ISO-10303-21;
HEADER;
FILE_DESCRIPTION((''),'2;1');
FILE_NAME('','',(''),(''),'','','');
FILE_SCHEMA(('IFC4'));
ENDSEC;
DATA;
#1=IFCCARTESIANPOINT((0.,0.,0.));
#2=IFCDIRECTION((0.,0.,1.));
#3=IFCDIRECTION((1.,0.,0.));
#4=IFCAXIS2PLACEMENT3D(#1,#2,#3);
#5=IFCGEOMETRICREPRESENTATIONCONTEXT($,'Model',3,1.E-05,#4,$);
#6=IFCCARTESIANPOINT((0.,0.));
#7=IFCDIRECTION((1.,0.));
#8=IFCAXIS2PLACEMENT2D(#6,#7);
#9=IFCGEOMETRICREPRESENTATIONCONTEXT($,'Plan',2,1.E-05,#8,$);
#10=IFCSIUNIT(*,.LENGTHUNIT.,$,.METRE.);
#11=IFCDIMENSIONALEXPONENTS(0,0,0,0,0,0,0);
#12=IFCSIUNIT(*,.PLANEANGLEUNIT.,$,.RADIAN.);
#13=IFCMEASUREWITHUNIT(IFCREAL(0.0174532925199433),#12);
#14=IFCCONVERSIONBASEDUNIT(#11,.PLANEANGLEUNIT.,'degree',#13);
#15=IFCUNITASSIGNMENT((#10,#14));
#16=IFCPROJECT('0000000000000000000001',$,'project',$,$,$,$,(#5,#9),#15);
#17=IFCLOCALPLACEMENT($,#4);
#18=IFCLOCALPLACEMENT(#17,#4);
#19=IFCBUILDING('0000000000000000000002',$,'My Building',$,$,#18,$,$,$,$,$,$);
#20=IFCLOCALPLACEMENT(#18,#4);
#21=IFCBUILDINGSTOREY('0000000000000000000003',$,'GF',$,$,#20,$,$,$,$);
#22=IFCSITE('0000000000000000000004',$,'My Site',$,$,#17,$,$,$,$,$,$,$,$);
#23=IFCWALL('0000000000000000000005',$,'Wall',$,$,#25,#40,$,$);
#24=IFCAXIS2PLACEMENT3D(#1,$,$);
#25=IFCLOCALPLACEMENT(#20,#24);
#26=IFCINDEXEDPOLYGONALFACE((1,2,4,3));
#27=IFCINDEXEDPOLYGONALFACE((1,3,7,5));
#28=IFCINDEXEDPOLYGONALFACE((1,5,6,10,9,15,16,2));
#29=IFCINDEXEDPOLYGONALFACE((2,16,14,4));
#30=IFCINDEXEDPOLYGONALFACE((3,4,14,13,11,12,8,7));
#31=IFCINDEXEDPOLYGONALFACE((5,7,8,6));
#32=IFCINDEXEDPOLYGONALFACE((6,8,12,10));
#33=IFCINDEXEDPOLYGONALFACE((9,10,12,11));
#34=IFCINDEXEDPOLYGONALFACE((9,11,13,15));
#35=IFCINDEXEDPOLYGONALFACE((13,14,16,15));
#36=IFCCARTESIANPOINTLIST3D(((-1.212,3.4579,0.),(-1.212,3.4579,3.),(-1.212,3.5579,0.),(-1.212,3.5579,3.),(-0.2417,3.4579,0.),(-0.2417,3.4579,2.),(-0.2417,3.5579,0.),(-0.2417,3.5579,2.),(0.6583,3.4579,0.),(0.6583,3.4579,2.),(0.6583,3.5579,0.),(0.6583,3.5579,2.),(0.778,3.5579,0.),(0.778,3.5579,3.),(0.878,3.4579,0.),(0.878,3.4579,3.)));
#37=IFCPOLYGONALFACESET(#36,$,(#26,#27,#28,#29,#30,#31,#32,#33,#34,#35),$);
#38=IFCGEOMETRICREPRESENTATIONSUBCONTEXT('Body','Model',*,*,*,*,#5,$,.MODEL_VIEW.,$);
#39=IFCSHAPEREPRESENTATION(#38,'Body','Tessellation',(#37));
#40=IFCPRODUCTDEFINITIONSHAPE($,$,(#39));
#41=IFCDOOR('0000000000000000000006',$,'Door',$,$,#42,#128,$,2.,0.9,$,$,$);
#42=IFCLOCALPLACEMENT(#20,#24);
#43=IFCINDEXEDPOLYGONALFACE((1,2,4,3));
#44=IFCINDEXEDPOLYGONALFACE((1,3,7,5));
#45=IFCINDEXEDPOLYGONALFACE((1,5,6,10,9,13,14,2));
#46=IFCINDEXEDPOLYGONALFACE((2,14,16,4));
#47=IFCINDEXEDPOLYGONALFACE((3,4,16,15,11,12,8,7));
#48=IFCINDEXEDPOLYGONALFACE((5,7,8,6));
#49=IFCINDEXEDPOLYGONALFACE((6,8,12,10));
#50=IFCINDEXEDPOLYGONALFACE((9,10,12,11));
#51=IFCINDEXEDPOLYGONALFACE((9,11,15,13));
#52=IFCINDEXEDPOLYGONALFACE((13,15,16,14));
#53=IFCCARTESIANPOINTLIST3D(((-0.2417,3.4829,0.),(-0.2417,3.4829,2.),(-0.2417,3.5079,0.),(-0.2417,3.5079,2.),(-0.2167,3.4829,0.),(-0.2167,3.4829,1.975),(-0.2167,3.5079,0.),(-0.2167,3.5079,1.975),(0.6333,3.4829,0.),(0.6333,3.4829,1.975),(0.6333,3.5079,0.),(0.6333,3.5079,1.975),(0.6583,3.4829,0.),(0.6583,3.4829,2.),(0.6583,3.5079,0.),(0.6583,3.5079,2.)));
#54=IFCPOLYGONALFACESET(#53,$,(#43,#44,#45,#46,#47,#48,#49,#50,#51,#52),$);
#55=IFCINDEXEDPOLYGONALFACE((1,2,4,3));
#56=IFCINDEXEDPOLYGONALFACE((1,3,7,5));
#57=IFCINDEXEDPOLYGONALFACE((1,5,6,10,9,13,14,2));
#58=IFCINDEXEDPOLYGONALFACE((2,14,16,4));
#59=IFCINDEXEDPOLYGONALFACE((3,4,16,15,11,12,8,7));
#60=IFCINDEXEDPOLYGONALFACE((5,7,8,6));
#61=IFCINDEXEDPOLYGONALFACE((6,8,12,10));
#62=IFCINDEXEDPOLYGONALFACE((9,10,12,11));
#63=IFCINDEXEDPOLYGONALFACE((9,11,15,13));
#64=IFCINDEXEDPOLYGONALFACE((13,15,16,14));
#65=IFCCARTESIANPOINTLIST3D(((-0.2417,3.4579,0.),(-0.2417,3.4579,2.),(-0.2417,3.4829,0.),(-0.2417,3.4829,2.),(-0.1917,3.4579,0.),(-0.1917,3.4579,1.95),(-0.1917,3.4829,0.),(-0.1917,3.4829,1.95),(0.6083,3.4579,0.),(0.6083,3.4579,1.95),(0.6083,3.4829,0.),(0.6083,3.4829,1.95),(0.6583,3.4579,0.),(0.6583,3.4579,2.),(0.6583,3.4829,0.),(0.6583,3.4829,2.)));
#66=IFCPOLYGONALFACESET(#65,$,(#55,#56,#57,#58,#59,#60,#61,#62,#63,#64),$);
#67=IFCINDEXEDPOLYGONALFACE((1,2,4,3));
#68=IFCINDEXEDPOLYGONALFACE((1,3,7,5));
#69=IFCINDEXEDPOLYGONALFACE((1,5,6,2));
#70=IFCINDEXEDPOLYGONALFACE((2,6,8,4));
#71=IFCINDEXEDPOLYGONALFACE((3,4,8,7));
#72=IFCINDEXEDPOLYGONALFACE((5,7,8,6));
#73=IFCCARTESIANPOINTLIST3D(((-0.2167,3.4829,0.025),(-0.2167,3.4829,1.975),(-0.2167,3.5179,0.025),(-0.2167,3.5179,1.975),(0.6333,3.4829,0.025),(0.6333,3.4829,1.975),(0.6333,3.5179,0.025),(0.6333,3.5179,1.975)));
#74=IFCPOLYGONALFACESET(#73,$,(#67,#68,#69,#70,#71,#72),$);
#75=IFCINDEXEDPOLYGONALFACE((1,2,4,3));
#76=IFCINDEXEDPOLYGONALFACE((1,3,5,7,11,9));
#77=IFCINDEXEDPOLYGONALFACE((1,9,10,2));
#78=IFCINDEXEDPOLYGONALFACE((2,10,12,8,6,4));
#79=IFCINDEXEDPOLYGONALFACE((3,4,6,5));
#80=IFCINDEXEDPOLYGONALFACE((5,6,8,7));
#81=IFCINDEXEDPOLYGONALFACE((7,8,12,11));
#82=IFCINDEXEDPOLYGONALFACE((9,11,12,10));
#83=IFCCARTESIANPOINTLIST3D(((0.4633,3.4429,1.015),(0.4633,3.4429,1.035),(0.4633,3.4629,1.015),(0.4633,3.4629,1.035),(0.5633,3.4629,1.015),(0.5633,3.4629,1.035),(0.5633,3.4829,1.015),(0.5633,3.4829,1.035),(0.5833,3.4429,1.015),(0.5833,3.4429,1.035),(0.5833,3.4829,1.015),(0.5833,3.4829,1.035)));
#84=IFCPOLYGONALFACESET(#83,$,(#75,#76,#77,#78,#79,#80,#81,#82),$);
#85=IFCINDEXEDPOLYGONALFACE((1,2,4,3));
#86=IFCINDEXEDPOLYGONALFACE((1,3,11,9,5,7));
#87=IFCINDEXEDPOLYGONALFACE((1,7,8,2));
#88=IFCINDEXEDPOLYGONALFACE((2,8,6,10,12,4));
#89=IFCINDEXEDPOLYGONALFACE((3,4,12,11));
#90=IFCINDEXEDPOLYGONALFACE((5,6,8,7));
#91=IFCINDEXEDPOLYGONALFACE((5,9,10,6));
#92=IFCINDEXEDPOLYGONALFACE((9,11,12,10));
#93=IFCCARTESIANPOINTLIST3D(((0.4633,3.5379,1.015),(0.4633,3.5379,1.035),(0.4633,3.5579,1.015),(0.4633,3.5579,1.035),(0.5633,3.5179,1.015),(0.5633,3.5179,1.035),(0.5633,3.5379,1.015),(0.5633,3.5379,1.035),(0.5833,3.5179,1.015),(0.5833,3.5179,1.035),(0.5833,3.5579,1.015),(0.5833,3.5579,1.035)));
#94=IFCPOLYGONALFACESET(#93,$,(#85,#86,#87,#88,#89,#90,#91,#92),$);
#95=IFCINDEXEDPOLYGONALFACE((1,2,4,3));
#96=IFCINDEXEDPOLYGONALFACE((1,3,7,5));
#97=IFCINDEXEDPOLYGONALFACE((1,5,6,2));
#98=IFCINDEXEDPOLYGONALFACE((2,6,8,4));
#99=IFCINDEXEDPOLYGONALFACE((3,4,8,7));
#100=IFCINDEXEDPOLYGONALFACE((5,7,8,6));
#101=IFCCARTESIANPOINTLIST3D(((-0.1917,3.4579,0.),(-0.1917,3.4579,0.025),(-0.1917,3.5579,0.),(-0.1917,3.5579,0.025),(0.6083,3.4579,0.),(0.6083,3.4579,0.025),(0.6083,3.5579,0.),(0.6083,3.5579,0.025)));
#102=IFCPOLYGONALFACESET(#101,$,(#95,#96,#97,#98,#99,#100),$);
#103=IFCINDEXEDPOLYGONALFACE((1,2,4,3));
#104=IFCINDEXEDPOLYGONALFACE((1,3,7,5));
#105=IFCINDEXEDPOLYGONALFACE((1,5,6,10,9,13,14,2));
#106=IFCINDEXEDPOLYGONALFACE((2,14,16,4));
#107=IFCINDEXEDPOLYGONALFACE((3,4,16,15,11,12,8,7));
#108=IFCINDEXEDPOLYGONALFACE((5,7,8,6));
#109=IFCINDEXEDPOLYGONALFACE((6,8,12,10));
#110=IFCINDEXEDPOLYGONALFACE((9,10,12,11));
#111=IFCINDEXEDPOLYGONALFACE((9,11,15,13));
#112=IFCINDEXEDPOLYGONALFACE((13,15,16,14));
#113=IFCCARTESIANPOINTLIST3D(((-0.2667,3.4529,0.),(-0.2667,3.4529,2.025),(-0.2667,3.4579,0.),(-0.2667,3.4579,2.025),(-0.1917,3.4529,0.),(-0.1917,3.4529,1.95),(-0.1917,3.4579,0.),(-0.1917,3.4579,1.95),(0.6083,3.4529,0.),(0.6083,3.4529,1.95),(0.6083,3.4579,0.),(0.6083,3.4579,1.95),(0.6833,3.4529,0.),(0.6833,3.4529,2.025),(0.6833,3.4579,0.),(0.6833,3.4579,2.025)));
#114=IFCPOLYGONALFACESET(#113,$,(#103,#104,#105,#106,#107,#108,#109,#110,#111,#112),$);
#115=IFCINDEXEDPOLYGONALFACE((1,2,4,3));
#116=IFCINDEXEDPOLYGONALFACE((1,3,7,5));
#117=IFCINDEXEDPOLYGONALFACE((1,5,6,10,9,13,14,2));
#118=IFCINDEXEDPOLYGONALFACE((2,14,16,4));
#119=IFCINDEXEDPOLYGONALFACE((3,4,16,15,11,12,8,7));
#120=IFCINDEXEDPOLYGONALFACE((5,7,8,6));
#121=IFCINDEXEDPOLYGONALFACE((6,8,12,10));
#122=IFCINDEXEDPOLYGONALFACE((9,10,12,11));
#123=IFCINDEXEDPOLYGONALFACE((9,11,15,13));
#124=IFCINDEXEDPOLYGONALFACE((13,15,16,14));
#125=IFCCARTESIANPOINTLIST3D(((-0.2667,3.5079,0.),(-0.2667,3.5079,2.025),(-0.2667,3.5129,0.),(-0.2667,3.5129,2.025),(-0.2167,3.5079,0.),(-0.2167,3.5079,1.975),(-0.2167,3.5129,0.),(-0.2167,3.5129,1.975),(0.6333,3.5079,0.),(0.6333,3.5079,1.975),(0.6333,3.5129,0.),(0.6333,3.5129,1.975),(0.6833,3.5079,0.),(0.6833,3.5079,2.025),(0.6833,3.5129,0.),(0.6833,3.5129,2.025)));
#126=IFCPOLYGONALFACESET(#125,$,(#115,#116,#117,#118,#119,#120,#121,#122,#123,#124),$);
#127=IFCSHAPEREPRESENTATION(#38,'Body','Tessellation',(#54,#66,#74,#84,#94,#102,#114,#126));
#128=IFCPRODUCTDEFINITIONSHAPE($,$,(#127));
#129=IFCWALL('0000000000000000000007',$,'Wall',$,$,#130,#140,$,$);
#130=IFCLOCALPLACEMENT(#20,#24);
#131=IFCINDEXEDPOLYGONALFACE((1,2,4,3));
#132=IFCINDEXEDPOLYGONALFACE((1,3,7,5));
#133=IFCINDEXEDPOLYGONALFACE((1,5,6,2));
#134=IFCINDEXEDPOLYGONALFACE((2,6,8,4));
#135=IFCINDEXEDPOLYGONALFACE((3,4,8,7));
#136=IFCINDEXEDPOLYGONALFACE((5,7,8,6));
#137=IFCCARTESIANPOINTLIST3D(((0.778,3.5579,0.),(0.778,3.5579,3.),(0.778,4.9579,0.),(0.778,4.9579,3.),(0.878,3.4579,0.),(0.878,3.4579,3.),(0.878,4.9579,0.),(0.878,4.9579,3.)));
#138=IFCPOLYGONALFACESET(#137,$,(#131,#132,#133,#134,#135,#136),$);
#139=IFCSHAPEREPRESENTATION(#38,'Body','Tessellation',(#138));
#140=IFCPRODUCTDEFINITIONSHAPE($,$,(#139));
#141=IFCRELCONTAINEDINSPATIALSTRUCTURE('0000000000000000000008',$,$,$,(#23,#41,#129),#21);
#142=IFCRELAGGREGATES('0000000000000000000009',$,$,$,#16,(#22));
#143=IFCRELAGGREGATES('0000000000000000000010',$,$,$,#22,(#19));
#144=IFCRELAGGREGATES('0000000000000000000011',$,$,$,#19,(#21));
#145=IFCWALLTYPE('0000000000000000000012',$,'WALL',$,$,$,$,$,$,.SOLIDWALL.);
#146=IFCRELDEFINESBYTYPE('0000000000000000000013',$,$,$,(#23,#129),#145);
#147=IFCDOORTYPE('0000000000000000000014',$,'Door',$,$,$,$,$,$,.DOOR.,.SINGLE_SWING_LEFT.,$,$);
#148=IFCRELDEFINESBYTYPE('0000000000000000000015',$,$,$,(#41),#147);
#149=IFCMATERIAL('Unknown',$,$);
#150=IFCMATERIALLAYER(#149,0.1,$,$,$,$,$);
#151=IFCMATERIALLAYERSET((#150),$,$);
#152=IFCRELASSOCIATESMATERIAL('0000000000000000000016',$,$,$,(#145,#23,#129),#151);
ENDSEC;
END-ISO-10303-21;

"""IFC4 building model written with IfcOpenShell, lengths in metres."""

from ifc_helpers import new_model, entity, si_unit, converted_unit, frame, origin_with_axes, origin_2d_with_axis, place, context, subcontext, project, spatial, line, indexed_curve, outline, extrude, shape, source, transform, mapped, material, layer, layer_set, layer_usage, type_object, type_shapes, element, fill, save


model = new_model("IFC4")

# Units and contexts
model_context = context("Model", 3, precision=1e-05, world=origin_with_axes())
plan_context = context("Plan", 2, precision=1e-05, world=origin_2d_with_axis())
body_context_1 = subcontext(model_context, "Body", "Model", "MODEL_VIEW")
body_context_2 = subcontext(plan_context, "Body", "Plan", "PLAN_VIEW")
ifc_project = project(units=[si_unit("LENGTHUNIT", "METRE"), converted_unit("PLANEANGLEUNIT", "degree", entity("IfcReal", 0.0174532925199433), si_unit("PLANEANGLEUNIT", "RADIAN"), dimensions=[0, 0, 0, 0, 0, 0, 0])], contexts=[model_context, plan_context])

# Site, building, storey
site_placement = place(None, origin_with_axes())
site = spatial("IfcSite", under=ifc_project, at=site_placement, Name="My Site")
building_placement = place(site_placement, origin_with_axes())
building = spatial("IfcBuilding", under=site, at=building_placement, Name="My Building")
storey_placement = place(building_placement, origin_with_axes())
storey = spatial("IfcBuildingStorey", under=building, at=storey_placement, Name="GF")

# Shared definitions
ifc_material = material(Name="Unknown")

# Shared definitions
ifc_layer_1 = layer(ifc_material, 0.1)
ifc_layer_set_1 = layer_set([ifc_layer_1])
wall_type = type_object("IfcWallType", Name="WALL", PredefinedType="SOLIDWALL", material=ifc_layer_set_1)
shared_shape_1 = source(origin_with_axes(), body_context_1, "Body", "SweptSolid", [
    extrude(outline(indexed_curve([(0.0, 0.0), (0.9, 0.0), (0.9, 2.0), (0.0, 2.0)], segments=[line(1, 2, 3, 4, 1)])), frame((0.0, -0.6, 0.0), z_axis=(0.0, -1.0, 0.0), x_axis=(1.0, 0.0, 0.0)), (0.0, 0.0, -1.0), 1.2),
])
door_type = type_object("IfcDoorType", Name="Door", OperationType="SINGLE_SWING_LEFT", PredefinedType="DOOR")
shared_shape_2 = source(origin_with_axes(), body_context_1, "Body", "SweptSolid", [
    extrude(outline(indexed_curve([(0.0, 0.0), (0.0, 2.0), (0.9, 2.0), (0.9, 0.0), (0.875, 0.0), (0.875, 1.975), (0.025, 1.975), (0.025, 0.0)], segments=[line(1, 2, 3, 4, 5, 6, 7, 8, 1)])), frame((0.0, 0.025, 0.0), z_axis=(0.0, -1.0, 0.0), x_axis=(1.0, 0.0, 0.0)), (0.0, 0.0, -1.0), 0.025),
    extrude(outline(indexed_curve([(0.0, 0.0), (0.0, 2.0), (0.9, 2.0), (0.9, 0.0), (0.85, 0.0), (0.85, 1.95), (0.05, 1.95), (0.05, 0.0)], segments=[line(1, 2, 3, 4, 5, 6, 7, 8, 1)])), frame((0.0, 0.0, 0.0), z_axis=(0.0, -1.0, 0.0), x_axis=(1.0, 0.0, 0.0)), (0.0, 0.0, -1.0), 0.025),
    extrude(outline(indexed_curve([(0.0, 0.0), (0.85, 0.0), (0.85, 0.035), (0.0, 0.035)], segments=[line(1, 2, 3, 4, 1)])), frame((0.025, 0.025, 0.025), z_axis=(0.0, 0.0, 1.0), x_axis=(1.0, 0.0, 0.0)), (0.0, 0.0, 1.0), 1.95),
    extrude(outline(indexed_curve([(0.0, 0.0), (0.0, -0.04), (-0.12, -0.04), (-0.12, -0.02), (-0.02, -0.02), (-0.02, 0.0)], segments=[line(1, 2, 3, 4, 5, 6, 1)])), frame((0.825, 0.025, 1.015), z_axis=(0.0, 0.0, 1.0), x_axis=(1.0, 0.0, 0.0)), (0.0, 0.0, 1.0), 0.02),
    extrude(outline(indexed_curve([(0.0, 0.0), (0.0, 0.04), (-0.12, 0.04), (-0.12, 0.02), (-0.02, 0.02), (-0.02, 0.0)], segments=[line(1, 2, 3, 4, 5, 6, 1)])), frame((0.825, 0.06, 1.015), z_axis=(0.0, 0.0, 1.0), x_axis=(1.0, 0.0, 0.0)), (0.0, 0.0, 1.0), 0.02),
    extrude(outline(indexed_curve([(0.0, 0.0), (0.8, 0.0), (0.8, 0.1), (0.0, 0.1)], segments=[line(1, 2, 3, 4, 1)])), frame((0.05, 0.0, 0.0), z_axis=(0.0, 0.0, 1.0), x_axis=(1.0, 0.0, 0.0)), (0.0, 0.0, 1.0), 0.025),
    extrude(outline(indexed_curve([(0.0, 0.0), (0.0, 2.025), (0.95, 2.025), (0.95, 0.0), (0.875, 0.0), (0.875, 1.95), (0.075, 1.95), (0.075, 0.0)], segments=[line(1, 2, 3, 4, 5, 6, 7, 8, 1)])), frame((-0.025, -0.005, 0.0), z_axis=(0.0, -1.0, 0.0), x_axis=(1.0, 0.0, 0.0)), (0.0, 0.0, -1.0), 0.005),
    extrude(outline(indexed_curve([(0.0, 0.0), (0.0, 2.025), (0.95, 2.025), (0.95, 0.0), (0.9, 0.0), (0.9, 1.975), (0.05, 1.975), (0.05, 0.0)], segments=[line(1, 2, 3, 4, 5, 6, 7, 8, 1)])), frame((-0.025, 0.05, 0.0), z_axis=(0.0, -1.0, 0.0), x_axis=(1.0, 0.0, 0.0)), (0.0, 0.0, -1.0), 0.005),
])
shared_shape_3 = source(origin_with_axes(), body_context_2, "Body", "Curve2D", [
    entity("IfcIndexedPolyCurve", entity("IfcCartesianPointList2D", [[0.0, 0.0], [0.0, 0.05], [0.025, 0.05], [0.025, 0.025], [0.05, 0.025], [0.05, 0.0]]), [entity("IfcLineIndex", [1, 2, 3, 4, 5, 6, 1])]),
    entity("IfcIndexedPolyCurve", entity("IfcCartesianPointList2D", [[0.9, 0.0], [0.9, 0.05], [0.875, 0.05], [0.875, 0.025], [0.85, 0.025], [0.85, 0.0]]), [entity("IfcLineIndex", [1, 2, 3, 4, 5, 6, 1])]),
    entity("IfcTrimmedCurve", entity("IfcEllipse", entity("IfcAxis2Placement2D", entity("IfcCartesianPoint", [0.06, 0.05]), entity("IfcDirection", [1.0, 0.0])), 0.815, 0.85), [entity("IfcCartesianPoint", [0.875, 0.05])], [entity("IfcCartesianPoint", [0.06, 0.9])], True, "CARTESIAN"),
    entity("IfcIndexedPolyCurve", entity("IfcCartesianPointList2D", [[0.025, 0.05], [0.06, 0.05], [0.06, 0.9], [0.025, 0.9]]), [entity("IfcLineIndex", [1, 2, 3, 4, 1])]),
])
type_shapes(door_type, [shared_shape_2, shared_shape_3])

# Wall, opening, door
ifc_layer_usage_1 = layer_usage(ifc_layer_set_1, "AXIS2", "POSITIVE", 0.0)
wall_1_placement = place(storey_placement, frame((-1.212, 3.4579, 0.0), z_axis=(0.0, 0.0, 1.0), x_axis=(1.0, 0.0, 0.0)))
wall_1 = element("IfcWall", 1, at=wall_1_placement, inside=storey, type_object=wall_type, material=ifc_layer_usage_1, Name="Wall", context=body_context_1, shape_type="SweptSolid", body=[
    extrude(outline(indexed_curve([(0.0, 0.0), (0.0, 0.1), (1.99, 0.1), (2.09, 0.0)], segments=[line(1, 2, 3, 4, 1)])), origin_with_axes(), (0.0, 0.0, 1.0), 3.0),
])
opening_1_placement = place(wall_1_placement, frame((0.9702, 0.0, 0.0), z_axis=(0.0, 0.0, 1.0), x_axis=(1.0, 0.0, 0.0)))
opening_1 = element("IfcOpeningElement", 2, at=opening_1_placement, cuts=wall_1, PredefinedType="OPENING", context=body_context_1, shape_type="MappedRepresentation", body=[
    mapped(shared_shape_1, transform((0.0, 0.0, 0.0), x_axis=(1.0, 0.0, 0.0), y_axis=(0.0, 1.0, 0.0), z_axis=(0.0, 0.0, 1.0), scale=1.0)),
])
door_1_placement = place(opening_1_placement, origin_with_axes())
door_1 = element("IfcDoor", 3, at=door_1_placement, inside=storey, type_object=door_type, Name="Door", OverallHeight=2.0, OverallWidth=0.9, shapes=[
    shape(body_context_1, "Body", "MappedRepresentation", [mapped(shared_shape_2, transform((0.0, 0.0, 0.0), x_axis=(1.0, 0.0, 0.0), y_axis=(0.0, 1.0, 0.0), z_axis=(0.0, 0.0, 1.0), scale=1.0))]),
    shape(body_context_2, "Body", "MappedRepresentation", [mapped(shared_shape_3, transform((0.0, 0.0, 0.0), x_axis=(1.0, 0.0, 0.0), y_axis=(0.0, 1.0, 0.0), z_axis=(0.0, 0.0, 1.0), scale=1.0))]),
])
fill(opening_1, door_1)

# Wall
ifc_layer_usage_2 = layer_usage(ifc_layer_set_1, "AXIS2", "POSITIVE", 0.0)
wall_2_placement = place(storey_placement, frame((0.878, 3.4579, 0.0), z_axis=(0.0, 0.0, 1.0), x_axis=(0.0, 1.0, 0.0)))
element("IfcWall", 4, at=wall_2_placement, inside=storey, type_object=wall_type, material=ifc_layer_usage_2, Name="Wall", context=body_context_1, shape_type="SweptSolid", body=[
    extrude(outline(indexed_curve([(0.0, 0.0), (0.1, 0.1), (1.5, 0.1), (1.5, 0.0)], segments=[line(1, 2, 3, 4, 1)])), origin_with_axes(), (0.0, 0.0, 1.0), 3.0),
])

save(model, "model.ifc")
